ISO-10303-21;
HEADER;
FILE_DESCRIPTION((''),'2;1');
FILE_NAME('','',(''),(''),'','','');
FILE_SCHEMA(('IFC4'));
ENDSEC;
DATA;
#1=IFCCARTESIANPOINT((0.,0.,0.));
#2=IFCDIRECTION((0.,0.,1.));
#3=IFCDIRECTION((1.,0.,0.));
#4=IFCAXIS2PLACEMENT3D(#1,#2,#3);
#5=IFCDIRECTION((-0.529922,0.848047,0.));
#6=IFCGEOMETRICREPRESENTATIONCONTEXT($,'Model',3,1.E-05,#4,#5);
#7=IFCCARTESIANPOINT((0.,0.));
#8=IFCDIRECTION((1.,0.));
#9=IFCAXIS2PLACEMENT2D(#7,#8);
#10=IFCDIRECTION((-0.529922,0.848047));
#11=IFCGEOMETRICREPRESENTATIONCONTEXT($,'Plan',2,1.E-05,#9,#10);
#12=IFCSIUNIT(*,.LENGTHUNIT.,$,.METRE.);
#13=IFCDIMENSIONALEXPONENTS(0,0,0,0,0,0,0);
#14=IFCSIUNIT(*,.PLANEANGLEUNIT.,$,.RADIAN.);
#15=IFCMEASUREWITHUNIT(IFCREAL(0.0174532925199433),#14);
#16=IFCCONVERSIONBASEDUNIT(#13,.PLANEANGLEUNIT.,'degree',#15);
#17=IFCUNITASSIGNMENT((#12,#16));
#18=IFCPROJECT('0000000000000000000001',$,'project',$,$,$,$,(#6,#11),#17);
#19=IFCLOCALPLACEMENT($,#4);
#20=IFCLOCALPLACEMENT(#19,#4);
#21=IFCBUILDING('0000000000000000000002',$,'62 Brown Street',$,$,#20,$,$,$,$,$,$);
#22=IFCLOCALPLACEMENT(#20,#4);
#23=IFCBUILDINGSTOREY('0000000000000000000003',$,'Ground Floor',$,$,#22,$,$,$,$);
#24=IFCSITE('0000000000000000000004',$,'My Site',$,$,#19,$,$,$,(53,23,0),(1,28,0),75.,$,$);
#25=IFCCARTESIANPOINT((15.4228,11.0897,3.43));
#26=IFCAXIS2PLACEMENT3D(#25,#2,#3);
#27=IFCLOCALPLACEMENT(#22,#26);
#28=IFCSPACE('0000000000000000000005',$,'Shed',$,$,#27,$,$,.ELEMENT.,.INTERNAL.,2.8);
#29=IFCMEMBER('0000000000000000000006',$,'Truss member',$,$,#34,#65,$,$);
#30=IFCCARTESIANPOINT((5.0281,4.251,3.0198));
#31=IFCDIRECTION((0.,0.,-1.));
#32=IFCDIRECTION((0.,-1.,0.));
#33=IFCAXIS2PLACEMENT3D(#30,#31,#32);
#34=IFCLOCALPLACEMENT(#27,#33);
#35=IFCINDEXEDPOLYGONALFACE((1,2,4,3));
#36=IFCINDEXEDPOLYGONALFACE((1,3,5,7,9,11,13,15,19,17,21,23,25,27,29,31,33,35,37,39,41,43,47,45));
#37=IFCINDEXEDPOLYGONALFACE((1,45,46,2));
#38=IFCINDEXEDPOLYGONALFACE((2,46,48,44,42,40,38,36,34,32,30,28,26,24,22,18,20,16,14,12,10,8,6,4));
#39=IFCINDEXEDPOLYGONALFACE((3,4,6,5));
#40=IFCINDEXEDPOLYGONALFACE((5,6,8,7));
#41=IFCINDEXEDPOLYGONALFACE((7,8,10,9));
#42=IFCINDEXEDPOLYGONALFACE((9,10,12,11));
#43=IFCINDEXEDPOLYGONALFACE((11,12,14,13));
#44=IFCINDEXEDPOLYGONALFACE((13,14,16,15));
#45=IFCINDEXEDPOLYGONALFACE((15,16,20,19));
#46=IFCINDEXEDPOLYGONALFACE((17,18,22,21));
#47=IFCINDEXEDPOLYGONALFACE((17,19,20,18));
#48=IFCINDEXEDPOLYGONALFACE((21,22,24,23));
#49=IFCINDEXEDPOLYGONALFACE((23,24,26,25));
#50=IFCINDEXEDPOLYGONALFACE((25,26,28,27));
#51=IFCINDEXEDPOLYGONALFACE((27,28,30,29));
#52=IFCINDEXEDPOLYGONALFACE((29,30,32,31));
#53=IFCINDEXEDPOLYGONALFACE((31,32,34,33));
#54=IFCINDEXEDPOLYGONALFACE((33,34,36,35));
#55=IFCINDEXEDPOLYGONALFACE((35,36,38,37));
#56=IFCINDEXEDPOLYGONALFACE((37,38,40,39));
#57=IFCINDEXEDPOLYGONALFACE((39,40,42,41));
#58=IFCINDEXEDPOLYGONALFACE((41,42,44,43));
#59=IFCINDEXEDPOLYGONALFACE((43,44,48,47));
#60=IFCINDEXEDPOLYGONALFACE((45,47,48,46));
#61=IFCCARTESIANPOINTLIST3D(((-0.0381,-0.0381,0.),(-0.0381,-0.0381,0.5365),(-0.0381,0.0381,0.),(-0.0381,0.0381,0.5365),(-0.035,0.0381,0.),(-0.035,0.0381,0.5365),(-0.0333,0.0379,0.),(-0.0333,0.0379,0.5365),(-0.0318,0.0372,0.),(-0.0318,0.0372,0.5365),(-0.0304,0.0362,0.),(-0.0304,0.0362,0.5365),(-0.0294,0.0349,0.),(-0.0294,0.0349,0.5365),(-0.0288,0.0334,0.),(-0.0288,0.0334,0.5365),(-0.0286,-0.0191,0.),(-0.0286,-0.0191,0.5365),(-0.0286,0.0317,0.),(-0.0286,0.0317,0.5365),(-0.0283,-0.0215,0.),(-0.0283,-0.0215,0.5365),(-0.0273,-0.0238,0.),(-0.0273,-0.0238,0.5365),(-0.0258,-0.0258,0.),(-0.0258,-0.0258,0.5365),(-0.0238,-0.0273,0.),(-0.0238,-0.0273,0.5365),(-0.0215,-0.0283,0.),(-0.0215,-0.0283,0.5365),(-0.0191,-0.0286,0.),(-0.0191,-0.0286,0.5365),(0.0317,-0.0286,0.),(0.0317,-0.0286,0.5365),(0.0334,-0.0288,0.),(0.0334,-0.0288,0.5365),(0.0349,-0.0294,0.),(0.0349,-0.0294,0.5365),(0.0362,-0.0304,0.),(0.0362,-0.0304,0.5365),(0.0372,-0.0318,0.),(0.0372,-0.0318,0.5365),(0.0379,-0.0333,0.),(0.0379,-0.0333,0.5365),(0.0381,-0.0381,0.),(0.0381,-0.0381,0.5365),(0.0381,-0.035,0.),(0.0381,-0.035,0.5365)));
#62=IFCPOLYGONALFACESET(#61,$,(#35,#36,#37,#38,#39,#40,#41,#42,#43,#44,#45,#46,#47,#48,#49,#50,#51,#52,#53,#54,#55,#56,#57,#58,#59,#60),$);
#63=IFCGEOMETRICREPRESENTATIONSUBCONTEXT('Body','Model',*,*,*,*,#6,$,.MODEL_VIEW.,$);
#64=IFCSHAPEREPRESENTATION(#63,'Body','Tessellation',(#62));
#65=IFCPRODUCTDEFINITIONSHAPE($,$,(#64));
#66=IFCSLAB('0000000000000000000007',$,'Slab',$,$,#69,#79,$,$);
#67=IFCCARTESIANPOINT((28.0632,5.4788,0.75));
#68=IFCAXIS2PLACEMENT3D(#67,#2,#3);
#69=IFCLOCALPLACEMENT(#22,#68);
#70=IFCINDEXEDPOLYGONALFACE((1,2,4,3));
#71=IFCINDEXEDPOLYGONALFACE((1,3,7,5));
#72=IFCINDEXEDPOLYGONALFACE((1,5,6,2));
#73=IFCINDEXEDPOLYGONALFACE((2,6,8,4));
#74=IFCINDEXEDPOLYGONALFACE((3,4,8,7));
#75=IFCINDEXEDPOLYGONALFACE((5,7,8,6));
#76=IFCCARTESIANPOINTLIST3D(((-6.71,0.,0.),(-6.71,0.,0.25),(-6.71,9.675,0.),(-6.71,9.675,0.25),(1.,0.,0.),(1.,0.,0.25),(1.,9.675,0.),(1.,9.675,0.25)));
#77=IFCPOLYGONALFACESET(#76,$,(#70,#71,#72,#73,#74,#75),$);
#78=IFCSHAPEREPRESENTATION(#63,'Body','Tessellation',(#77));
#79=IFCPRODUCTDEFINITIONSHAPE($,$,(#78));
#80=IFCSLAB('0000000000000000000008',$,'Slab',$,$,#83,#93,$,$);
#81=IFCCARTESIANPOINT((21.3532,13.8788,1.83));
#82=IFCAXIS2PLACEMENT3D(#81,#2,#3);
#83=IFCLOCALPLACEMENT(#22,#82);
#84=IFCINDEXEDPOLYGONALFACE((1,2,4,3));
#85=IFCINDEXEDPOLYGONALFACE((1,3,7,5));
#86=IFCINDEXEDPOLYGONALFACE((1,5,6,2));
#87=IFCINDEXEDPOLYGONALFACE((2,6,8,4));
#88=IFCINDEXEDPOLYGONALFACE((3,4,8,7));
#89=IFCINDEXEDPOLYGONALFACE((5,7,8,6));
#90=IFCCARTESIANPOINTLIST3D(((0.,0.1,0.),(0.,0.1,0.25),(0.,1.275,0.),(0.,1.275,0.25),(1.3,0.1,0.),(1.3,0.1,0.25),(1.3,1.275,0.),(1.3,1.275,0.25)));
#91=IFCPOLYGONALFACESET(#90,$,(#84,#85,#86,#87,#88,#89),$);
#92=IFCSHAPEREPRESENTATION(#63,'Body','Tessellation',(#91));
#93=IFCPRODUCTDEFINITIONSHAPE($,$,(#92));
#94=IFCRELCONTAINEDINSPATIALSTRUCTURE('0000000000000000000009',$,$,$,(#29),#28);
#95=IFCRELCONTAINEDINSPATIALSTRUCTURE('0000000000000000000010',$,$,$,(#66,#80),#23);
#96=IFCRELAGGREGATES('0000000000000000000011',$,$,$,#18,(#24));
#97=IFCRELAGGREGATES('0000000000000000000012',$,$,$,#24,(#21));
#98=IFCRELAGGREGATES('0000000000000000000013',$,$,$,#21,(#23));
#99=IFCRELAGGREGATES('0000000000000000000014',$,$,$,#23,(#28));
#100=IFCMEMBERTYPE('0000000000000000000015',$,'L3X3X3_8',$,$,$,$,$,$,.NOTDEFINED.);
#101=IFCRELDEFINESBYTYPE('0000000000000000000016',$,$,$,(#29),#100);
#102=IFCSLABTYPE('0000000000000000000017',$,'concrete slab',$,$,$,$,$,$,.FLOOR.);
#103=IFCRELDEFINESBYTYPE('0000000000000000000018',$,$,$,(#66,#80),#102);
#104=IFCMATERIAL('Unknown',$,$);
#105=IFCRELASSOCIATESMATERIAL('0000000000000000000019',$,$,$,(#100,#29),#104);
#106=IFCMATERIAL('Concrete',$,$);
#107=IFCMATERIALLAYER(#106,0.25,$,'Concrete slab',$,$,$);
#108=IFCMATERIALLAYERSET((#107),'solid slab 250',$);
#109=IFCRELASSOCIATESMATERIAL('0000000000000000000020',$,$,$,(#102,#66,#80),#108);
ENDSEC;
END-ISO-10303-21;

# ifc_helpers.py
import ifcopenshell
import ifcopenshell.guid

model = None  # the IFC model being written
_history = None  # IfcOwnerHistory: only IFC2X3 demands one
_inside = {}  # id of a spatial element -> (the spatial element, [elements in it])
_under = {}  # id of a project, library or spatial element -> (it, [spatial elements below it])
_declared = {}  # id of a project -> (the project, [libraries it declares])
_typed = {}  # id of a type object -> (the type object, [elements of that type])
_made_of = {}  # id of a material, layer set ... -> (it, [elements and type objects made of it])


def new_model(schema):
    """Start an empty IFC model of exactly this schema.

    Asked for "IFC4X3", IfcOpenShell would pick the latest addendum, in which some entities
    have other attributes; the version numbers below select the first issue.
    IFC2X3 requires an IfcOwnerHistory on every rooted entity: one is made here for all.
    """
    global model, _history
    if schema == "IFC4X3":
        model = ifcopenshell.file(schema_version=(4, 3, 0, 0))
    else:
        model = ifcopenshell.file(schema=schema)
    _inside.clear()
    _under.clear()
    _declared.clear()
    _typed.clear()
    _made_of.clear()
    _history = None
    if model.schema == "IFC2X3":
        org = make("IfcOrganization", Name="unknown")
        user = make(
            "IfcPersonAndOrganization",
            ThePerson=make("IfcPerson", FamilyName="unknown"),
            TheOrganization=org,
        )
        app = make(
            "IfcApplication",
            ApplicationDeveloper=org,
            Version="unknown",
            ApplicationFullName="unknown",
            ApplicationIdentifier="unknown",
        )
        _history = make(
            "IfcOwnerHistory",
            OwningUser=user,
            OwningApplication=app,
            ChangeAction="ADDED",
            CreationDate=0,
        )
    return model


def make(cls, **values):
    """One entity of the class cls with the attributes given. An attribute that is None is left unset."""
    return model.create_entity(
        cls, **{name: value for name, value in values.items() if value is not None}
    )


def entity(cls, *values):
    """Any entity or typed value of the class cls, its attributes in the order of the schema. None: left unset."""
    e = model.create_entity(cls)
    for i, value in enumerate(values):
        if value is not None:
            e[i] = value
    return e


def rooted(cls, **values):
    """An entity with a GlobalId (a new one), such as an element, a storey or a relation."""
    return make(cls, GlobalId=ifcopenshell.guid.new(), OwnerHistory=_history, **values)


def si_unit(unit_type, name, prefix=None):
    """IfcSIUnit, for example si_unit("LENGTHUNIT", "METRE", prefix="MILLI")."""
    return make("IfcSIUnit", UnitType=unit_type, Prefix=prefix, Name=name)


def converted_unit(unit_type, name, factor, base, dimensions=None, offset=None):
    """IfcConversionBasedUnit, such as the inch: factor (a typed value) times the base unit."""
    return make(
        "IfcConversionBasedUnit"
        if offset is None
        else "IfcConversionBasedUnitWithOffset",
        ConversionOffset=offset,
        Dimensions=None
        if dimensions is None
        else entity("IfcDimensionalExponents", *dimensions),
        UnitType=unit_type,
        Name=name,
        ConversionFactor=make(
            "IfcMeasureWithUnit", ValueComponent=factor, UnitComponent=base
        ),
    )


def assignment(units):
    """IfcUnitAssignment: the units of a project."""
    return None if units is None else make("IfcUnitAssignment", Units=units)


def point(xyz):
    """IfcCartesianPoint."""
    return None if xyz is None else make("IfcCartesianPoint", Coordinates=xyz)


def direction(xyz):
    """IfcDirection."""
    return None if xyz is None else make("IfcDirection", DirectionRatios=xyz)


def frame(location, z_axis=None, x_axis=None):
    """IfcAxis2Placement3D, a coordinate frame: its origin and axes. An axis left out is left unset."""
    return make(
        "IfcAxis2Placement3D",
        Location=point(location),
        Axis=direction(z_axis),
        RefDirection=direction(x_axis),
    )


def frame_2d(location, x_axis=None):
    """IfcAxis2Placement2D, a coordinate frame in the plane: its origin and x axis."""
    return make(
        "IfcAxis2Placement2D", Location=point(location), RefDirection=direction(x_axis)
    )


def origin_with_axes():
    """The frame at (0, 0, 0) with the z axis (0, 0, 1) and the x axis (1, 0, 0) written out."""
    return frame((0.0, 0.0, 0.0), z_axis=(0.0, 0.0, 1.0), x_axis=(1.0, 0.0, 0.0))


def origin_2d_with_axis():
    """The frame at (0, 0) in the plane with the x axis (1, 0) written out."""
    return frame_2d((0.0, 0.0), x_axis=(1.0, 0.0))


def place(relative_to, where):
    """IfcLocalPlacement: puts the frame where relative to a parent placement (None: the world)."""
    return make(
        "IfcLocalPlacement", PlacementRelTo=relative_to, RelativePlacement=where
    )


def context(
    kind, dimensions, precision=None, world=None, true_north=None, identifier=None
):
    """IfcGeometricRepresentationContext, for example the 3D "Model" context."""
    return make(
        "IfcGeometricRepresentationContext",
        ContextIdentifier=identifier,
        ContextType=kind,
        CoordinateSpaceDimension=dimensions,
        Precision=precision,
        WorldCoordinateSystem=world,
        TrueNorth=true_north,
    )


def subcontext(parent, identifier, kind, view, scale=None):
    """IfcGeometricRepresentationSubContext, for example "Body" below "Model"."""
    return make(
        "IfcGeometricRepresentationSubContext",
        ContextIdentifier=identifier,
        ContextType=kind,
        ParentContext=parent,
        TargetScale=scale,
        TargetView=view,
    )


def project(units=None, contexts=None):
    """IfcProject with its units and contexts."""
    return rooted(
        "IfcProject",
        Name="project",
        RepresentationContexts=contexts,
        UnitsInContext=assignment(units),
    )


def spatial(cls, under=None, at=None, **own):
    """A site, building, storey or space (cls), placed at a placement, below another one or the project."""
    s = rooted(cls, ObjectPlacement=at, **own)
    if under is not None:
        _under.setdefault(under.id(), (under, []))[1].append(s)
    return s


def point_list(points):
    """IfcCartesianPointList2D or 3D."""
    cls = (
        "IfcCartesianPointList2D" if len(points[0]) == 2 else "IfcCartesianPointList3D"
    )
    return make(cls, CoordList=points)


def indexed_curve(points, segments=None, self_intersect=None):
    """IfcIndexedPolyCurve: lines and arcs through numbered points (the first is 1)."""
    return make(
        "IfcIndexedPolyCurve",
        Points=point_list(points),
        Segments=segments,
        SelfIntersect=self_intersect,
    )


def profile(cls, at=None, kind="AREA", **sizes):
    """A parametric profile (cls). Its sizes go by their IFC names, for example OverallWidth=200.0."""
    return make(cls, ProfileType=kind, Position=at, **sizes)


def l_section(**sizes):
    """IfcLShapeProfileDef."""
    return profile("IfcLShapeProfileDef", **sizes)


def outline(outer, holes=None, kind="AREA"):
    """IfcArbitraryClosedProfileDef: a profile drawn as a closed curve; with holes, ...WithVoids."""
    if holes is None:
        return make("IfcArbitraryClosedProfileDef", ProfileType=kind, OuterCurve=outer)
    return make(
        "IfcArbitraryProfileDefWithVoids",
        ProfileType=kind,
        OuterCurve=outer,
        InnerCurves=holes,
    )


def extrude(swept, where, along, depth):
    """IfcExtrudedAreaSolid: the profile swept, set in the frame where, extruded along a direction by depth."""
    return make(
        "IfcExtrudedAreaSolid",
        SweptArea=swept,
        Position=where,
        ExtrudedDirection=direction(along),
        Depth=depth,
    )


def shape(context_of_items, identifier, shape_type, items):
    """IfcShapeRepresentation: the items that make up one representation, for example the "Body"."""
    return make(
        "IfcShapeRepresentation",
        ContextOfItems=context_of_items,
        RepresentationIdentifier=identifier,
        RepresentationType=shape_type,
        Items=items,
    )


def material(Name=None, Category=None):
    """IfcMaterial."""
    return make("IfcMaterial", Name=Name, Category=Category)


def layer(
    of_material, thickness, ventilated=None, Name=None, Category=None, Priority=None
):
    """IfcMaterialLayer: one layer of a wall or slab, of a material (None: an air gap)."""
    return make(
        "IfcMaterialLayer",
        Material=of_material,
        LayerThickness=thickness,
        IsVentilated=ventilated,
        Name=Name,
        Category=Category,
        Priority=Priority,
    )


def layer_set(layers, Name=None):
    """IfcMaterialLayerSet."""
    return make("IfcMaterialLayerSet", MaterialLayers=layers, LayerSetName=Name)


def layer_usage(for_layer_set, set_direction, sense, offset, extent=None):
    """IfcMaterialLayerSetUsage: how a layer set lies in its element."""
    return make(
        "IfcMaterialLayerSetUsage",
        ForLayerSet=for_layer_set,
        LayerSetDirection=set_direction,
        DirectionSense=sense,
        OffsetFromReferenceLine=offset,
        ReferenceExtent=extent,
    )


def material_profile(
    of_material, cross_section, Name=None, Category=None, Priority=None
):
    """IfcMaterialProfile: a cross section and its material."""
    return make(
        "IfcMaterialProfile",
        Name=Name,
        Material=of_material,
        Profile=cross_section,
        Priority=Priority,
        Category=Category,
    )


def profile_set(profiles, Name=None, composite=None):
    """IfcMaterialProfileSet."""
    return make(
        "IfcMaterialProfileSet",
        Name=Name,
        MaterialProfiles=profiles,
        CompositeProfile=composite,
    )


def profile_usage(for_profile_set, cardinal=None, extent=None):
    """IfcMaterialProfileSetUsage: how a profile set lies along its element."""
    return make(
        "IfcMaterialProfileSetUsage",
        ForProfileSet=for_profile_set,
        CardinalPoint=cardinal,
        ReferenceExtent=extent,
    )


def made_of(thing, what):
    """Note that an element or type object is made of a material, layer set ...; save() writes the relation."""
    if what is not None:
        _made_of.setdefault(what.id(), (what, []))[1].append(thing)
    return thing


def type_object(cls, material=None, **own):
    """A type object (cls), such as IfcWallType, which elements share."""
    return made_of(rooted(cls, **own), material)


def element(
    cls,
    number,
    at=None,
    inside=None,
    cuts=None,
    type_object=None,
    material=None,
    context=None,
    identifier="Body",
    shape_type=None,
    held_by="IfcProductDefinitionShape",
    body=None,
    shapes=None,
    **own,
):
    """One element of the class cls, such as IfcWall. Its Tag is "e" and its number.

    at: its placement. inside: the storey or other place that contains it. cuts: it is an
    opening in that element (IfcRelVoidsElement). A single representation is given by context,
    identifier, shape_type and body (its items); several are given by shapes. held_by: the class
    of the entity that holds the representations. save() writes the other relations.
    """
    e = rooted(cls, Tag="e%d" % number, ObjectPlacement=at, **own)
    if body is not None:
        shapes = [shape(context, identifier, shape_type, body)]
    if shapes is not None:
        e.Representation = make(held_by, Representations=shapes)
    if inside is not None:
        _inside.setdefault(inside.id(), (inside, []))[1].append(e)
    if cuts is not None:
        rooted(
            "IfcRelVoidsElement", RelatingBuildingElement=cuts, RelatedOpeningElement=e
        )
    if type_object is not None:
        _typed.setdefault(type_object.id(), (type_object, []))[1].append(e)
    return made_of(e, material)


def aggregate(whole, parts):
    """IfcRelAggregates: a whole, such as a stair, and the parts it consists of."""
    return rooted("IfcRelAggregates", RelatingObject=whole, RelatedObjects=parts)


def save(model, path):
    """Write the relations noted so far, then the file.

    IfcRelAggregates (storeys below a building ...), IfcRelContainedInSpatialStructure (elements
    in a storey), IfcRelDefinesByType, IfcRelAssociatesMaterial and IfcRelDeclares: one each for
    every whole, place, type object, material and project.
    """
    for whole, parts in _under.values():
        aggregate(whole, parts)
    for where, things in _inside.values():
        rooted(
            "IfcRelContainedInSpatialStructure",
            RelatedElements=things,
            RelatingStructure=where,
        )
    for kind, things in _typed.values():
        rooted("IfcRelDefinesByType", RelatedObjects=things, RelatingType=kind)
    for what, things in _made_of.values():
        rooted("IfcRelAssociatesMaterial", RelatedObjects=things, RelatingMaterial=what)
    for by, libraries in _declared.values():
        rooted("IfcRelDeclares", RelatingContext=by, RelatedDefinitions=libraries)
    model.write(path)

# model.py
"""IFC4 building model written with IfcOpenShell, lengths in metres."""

from ifc_helpers import new_model, entity, si_unit, converted_unit, direction, frame, origin_with_axes, origin_2d_with_axis, place, context, subcontext, project, spatial, indexed_curve, l_section, outline, extrude, material, layer, layer_set, layer_usage, material_profile, profile_set, profile_usage, type_object, element, save


model = new_model("IFC4")

# Units and contexts
model_context = context("Model", 3, precision=1e-05, world=origin_with_axes(), true_north=direction((-0.529922, 0.848047, 0.0)))
plan_context = context("Plan", 2, precision=1e-05, world=origin_2d_with_axis(), true_north=direction((-0.529922, 0.848047)))
body_context = subcontext(model_context, "Body", "Model", "MODEL_VIEW")
ifc_project = project(units=[si_unit("LENGTHUNIT", "METRE"), converted_unit("PLANEANGLEUNIT", "degree", entity("IfcReal", 0.0174532925199433), si_unit("PLANEANGLEUNIT", "RADIAN"), dimensions=[0, 0, 0, 0, 0, 0, 0])], contexts=[model_context, plan_context])

# Site, building, storey
site_placement = place(None, origin_with_axes())
site = spatial("IfcSite", under=ifc_project, at=site_placement, Name="My Site", RefLatitude=(53, 23, 0), RefLongitude=(1, 28, 0), RefElevation=75.0)
building_placement = place(site_placement, origin_with_axes())
building = spatial("IfcBuilding", under=site, at=building_placement, Name="62 Brown Street")
storey_placement = place(building_placement, origin_with_axes())
storey = spatial("IfcBuildingStorey", under=building, at=storey_placement, Name="Ground Floor")

# Shared definitions
ifc_material_1 = material(Name="Concrete")

# Shared definitions
ifc_material_2 = material(Name="Unknown")
ifc_material_profile_1 = material_profile(ifc_material_2, l_section(Depth=0.0762, Width=0.0762, Thickness=0.0095, FilletRadius=0.0095, EdgeRadius=0.0064))
ifc_profile_set_1 = profile_set([ifc_material_profile_1])
member_type_1 = type_object("IfcMemberType", Name="L3X3X3_8", PredefinedType="NOTDEFINED", material=ifc_profile_set_1)

# Shared definitions
space_1_placement = place(storey_placement, frame((15.4228, 11.0897, 3.43), z_axis=(0.0, 0.0, 1.0), x_axis=(1.0, 0.0, 0.0)))
space_1 = spatial("IfcSpace", under=storey, at=space_1_placement, Name="Shed", CompositionType="ELEMENT", PredefinedType="INTERNAL", ElevationWithFlooring=2.8)

# Member
ifc_profile_usage_1 = profile_usage(ifc_profile_set_1, cardinal=5)
member_1_placement = place(space_1_placement, frame((5.0281, 4.251, 3.0198), z_axis=(0.0, 0.0, -1.0), x_axis=(0.0, -1.0, 0.0)))
element("IfcMember", 1, at=member_1_placement, inside=space_1, type_object=member_type_1, material=ifc_profile_usage_1, Name="Truss member", context=body_context, shape_type="SweptSolid", body=[
    extrude(l_section(Depth=0.0762, Width=0.0762, Thickness=0.0095, FilletRadius=0.0095, EdgeRadius=0.0064), origin_with_axes(), (0.0, 0.0, 1.0), 0.5365),
])

# Slabs
ifc_layer_1 = layer(ifc_material_1, 0.25, Name="Concrete slab")
ifc_layer_set_1 = layer_set([ifc_layer_1], Name="solid slab 250")
slab_type = type_object("IfcSlabType", Name="concrete slab", PredefinedType="FLOOR", material=ifc_layer_set_1)
ifc_layer_usage_1 = layer_usage(ifc_layer_set_1, "AXIS3", "POSITIVE", 0.0)
slab_1_placement = place(storey_placement, frame((28.0632, 5.4788, 0.75), z_axis=(0.0, 0.0, 1.0), x_axis=(1.0, 0.0, 0.0)))
element("IfcSlab", 2, at=slab_1_placement, inside=storey, type_object=slab_type, material=ifc_layer_usage_1, Name="Slab", context=body_context, shape_type="SweptSolid", body=[
    extrude(outline(indexed_curve([(-6.71, 0.0), (-6.71, 9.675), (1.0, 9.675), (1.0, 0.0), (-6.71, 0.0)])), None, (0.0, 0.0, 1.0), 0.25),
])
ifc_layer_usage_2 = layer_usage(ifc_layer_set_1, "AXIS3", "POSITIVE", 0.0)
slab_2_placement = place(storey_placement, frame((21.3532, 13.8788, 1.83), z_axis=(0.0, 0.0, 1.0), x_axis=(1.0, 0.0, 0.0)))
element("IfcSlab", 3, at=slab_2_placement, inside=storey, type_object=slab_type, material=ifc_layer_usage_2, Name="Slab", context=body_context, shape_type="SweptSolid", body=[
    extrude(outline(indexed_curve([(0.0, 0.1), (1.3, 0.1), (1.3, 1.275), (0.0, 1.275), (0.0, 0.1)])), None, (0.0, 0.0, 1.0), 0.25),
])

save(model, "model.ifc")
